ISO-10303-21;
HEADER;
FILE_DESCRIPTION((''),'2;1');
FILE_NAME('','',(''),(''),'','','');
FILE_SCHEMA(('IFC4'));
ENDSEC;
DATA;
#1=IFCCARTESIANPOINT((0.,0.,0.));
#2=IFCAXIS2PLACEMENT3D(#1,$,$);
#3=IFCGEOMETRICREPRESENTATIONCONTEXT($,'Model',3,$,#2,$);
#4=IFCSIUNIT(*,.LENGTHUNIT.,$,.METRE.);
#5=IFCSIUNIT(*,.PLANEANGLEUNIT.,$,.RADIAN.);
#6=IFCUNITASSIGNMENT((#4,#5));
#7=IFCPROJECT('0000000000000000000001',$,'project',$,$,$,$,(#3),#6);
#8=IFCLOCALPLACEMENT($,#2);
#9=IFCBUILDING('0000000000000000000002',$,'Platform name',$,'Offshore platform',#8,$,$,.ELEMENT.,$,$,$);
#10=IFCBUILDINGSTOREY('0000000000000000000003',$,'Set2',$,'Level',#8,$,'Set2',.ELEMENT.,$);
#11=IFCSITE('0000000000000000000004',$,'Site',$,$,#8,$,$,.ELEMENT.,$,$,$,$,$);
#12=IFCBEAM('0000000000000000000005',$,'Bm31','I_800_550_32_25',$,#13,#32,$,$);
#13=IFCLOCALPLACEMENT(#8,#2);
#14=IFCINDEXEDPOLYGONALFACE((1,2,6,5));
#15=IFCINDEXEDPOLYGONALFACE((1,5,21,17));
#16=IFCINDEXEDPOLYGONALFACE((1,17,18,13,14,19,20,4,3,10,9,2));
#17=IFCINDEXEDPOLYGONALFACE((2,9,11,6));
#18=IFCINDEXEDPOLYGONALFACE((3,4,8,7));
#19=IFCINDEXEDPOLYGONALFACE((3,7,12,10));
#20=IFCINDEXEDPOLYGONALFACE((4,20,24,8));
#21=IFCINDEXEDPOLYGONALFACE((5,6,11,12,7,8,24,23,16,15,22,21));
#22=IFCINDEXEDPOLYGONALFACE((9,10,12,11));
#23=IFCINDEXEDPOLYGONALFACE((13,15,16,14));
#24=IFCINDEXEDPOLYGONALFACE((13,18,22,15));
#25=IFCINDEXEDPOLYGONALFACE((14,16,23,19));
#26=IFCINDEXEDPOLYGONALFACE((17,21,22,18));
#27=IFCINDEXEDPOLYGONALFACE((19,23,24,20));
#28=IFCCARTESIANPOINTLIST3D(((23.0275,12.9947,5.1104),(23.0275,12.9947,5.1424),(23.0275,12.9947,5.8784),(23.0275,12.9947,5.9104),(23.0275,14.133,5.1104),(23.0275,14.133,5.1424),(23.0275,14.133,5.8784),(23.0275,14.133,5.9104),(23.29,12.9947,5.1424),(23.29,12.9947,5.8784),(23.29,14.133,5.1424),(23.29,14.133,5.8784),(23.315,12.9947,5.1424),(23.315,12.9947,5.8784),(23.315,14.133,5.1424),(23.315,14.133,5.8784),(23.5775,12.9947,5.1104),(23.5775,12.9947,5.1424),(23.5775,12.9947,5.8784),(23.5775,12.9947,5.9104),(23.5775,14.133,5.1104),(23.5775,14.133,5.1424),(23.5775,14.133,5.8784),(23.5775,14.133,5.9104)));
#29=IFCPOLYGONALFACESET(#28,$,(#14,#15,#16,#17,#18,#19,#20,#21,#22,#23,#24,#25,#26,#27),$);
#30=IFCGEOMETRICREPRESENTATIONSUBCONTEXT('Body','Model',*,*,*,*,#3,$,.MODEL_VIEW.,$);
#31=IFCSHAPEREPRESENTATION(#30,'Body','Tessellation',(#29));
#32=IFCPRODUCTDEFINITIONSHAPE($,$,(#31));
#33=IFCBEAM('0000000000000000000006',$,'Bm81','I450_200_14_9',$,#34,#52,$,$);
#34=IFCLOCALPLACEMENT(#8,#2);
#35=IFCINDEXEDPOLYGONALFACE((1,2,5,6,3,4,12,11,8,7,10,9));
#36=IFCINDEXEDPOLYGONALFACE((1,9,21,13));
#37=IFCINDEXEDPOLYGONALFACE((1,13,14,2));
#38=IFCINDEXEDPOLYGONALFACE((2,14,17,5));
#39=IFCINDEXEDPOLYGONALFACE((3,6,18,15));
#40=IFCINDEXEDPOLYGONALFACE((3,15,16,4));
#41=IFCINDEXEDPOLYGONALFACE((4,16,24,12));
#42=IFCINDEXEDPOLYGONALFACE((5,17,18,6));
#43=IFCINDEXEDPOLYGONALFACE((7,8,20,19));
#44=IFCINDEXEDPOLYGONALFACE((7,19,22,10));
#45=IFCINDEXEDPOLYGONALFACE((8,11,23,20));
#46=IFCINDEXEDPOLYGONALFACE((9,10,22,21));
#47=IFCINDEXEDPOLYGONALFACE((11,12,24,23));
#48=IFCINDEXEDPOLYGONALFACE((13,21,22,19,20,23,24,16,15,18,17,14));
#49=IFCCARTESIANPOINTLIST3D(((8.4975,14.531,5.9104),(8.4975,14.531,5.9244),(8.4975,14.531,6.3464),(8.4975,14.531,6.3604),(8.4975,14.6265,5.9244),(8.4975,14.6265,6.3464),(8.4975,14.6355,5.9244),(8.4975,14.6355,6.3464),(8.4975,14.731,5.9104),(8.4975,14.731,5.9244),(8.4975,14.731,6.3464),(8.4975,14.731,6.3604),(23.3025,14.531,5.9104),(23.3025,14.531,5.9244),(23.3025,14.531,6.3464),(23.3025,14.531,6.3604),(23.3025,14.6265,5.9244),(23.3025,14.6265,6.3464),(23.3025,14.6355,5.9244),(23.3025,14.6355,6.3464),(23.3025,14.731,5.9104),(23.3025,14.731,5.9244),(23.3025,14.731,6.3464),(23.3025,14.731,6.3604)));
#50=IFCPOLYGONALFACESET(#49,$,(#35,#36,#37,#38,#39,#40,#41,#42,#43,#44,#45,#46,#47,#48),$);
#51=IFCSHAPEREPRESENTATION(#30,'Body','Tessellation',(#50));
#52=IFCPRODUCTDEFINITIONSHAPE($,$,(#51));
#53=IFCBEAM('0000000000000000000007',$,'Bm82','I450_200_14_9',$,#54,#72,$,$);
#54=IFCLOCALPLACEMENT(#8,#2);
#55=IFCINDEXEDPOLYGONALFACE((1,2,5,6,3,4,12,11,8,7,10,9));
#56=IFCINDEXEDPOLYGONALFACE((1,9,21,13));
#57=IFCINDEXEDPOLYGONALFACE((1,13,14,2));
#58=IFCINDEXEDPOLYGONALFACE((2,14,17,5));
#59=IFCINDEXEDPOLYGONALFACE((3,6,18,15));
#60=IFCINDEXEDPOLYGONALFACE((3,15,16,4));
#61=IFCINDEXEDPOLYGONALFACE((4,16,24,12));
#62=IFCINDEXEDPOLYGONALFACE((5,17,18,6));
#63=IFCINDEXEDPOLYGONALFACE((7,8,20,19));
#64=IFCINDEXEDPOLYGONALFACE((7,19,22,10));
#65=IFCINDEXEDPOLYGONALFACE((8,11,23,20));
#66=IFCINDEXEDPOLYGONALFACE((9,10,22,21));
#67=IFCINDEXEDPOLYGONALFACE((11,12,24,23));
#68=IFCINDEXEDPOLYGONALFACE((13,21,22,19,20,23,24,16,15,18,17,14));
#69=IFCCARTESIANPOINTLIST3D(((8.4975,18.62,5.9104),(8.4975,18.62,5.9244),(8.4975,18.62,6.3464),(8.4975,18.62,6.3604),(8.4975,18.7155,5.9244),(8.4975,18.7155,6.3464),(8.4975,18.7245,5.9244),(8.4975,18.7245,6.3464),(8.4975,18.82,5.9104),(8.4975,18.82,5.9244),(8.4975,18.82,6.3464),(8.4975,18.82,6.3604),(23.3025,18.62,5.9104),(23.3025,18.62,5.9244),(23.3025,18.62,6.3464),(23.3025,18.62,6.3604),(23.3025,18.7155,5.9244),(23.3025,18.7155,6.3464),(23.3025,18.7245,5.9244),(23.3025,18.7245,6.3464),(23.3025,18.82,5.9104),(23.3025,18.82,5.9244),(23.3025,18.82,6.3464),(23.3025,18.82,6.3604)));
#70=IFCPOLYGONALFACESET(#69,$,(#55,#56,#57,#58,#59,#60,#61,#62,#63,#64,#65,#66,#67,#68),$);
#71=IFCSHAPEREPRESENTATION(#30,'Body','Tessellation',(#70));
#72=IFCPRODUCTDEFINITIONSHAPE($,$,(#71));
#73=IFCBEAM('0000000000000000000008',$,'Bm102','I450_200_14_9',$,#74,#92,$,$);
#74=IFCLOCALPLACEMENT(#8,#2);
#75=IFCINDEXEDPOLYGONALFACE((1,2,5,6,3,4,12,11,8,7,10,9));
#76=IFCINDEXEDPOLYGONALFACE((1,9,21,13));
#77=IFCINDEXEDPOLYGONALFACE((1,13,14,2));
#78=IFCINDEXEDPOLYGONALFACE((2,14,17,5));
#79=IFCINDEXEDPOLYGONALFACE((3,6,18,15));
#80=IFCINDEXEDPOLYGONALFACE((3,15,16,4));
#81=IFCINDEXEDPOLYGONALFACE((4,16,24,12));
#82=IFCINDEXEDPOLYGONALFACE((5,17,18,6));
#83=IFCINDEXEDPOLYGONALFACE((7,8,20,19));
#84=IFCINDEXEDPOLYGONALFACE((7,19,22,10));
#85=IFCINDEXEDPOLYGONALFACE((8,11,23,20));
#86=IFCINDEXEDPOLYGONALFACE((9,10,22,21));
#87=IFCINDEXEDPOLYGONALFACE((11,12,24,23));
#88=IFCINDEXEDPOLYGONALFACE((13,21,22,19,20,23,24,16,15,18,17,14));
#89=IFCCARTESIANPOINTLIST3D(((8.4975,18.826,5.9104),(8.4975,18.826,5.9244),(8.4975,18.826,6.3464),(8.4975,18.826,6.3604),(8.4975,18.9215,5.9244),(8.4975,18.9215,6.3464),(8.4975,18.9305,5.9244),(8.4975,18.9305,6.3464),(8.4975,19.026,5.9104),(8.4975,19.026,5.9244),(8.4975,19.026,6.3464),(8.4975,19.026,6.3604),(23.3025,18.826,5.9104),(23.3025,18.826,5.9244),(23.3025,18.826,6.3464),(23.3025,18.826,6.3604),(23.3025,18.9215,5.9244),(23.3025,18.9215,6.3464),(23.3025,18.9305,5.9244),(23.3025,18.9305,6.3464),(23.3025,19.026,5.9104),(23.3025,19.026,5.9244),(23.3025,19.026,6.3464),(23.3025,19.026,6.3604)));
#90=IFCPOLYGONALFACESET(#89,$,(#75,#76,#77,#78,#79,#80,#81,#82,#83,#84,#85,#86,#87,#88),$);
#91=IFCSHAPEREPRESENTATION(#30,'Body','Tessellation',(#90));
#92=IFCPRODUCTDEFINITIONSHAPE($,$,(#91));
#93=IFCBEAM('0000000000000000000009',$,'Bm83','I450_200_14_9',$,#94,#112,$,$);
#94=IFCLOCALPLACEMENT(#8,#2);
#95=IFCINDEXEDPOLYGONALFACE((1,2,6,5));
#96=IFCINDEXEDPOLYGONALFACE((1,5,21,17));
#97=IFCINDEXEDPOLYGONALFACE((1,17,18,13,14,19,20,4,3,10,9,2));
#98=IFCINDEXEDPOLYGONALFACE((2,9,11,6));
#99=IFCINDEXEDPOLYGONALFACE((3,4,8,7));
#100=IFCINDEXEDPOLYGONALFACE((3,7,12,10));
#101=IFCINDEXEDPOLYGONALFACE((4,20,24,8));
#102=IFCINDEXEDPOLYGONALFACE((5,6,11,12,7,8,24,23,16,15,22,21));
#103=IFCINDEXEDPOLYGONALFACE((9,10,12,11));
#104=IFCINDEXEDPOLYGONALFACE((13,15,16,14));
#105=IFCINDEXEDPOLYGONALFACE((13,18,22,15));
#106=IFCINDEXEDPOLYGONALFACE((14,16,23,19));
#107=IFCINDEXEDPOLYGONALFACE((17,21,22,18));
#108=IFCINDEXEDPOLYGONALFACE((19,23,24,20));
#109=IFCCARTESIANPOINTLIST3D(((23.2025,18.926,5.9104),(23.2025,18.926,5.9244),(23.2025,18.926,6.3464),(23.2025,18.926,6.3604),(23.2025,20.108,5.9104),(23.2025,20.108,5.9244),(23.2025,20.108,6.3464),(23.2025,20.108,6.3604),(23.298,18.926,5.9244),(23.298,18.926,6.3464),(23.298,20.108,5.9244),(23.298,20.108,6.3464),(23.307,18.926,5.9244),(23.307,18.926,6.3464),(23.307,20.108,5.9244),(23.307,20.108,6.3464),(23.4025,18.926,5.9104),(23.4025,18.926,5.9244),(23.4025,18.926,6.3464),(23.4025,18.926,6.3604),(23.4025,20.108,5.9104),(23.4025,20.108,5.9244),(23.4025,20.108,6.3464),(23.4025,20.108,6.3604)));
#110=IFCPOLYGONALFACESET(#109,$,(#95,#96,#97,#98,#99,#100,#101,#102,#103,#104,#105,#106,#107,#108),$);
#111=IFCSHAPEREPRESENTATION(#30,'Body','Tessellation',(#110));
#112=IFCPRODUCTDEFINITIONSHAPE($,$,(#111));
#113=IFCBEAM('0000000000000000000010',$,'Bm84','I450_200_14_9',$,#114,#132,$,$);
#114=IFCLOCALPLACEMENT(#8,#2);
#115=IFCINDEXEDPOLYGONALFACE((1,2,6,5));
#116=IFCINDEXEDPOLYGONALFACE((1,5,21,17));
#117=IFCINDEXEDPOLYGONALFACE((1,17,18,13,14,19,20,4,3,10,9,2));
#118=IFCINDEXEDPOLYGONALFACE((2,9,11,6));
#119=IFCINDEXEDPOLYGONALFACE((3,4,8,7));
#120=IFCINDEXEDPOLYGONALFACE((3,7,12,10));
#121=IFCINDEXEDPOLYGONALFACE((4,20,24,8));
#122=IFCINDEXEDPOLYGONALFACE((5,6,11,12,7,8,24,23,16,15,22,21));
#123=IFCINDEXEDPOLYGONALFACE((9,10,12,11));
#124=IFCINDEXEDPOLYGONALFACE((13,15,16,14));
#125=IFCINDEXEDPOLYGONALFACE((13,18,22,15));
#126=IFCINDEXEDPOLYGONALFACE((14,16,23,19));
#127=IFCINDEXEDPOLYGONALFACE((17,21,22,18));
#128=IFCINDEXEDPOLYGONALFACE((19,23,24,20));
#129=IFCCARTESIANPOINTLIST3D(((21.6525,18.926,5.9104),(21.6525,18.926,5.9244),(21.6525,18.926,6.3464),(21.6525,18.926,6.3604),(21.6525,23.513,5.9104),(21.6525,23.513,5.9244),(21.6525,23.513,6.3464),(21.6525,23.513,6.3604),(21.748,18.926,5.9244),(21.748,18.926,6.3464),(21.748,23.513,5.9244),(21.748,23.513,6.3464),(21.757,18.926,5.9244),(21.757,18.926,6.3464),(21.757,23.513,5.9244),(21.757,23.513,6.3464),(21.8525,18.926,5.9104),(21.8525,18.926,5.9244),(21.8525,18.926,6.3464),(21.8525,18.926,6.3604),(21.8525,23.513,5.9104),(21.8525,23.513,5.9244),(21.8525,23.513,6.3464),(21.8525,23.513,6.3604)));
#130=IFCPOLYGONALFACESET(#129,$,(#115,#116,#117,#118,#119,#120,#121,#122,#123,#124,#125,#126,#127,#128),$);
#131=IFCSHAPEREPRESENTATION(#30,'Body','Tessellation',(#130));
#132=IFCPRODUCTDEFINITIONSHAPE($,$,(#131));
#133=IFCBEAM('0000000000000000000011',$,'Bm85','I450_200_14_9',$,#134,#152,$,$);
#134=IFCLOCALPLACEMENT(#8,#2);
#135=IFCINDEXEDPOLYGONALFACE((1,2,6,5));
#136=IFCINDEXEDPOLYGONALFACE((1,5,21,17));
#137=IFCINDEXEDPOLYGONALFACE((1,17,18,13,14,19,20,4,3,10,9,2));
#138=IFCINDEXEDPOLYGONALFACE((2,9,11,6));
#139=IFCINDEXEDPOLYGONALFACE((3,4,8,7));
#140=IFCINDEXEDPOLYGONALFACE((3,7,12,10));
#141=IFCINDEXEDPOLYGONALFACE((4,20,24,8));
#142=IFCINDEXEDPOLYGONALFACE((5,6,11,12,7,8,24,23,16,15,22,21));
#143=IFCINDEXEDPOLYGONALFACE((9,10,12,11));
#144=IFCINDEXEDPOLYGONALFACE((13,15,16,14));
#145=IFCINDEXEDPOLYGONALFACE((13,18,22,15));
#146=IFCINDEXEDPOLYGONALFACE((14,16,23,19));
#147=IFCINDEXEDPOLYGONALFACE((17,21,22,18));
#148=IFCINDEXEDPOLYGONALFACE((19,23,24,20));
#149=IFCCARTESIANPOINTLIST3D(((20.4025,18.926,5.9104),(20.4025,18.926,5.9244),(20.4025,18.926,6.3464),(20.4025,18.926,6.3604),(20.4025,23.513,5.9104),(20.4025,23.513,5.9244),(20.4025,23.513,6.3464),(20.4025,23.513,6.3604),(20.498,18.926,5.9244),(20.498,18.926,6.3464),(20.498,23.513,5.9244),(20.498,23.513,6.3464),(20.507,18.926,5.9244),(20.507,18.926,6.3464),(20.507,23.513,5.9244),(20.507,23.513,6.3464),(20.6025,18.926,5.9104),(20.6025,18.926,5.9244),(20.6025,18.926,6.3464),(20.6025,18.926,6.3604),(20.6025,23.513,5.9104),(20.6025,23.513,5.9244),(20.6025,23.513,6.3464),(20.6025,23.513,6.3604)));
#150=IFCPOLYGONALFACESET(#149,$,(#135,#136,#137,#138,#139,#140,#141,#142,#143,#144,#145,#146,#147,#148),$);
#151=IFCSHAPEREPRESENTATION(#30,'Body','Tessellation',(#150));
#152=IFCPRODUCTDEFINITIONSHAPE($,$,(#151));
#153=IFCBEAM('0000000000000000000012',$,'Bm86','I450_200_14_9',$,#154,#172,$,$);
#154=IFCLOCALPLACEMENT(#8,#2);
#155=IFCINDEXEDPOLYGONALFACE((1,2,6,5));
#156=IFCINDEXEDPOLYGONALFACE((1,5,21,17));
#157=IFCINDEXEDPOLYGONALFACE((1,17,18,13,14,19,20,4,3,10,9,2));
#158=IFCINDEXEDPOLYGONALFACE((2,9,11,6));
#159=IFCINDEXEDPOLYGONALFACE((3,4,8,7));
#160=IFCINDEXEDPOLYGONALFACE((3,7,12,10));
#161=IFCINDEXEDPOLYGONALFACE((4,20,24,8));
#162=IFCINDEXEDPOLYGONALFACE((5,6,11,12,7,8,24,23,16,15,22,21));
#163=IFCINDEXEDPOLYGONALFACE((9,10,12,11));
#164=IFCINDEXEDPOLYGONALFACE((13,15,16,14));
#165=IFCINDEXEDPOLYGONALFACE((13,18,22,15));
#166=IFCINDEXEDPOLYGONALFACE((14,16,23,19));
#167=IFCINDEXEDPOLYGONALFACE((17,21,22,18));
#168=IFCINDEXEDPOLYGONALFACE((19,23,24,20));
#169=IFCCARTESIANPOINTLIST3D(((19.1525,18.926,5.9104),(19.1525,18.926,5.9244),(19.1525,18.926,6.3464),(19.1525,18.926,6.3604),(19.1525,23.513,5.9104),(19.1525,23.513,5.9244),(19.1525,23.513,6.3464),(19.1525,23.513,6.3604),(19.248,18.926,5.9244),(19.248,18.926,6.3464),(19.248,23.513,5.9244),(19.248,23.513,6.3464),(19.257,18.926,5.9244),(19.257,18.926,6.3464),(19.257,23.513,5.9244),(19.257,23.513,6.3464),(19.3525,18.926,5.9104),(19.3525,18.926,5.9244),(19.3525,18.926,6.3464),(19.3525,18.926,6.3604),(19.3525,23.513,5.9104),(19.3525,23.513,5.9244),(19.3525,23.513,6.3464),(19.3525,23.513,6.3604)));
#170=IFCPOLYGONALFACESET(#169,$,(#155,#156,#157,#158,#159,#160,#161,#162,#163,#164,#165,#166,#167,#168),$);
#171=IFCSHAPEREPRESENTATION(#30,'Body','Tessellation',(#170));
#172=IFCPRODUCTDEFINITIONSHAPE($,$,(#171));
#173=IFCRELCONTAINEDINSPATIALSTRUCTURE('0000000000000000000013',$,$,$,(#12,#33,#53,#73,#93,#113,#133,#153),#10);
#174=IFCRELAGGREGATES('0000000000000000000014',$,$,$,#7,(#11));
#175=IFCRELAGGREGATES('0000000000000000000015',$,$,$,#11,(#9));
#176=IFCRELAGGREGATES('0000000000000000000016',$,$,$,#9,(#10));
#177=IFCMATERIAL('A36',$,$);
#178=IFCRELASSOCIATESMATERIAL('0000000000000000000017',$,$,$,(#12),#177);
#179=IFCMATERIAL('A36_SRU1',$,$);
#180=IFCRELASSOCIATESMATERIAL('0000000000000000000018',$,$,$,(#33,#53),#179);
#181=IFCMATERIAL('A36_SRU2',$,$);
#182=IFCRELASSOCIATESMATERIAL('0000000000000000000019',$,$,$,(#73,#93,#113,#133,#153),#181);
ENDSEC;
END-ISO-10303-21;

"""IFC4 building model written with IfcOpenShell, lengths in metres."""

from ifc_helpers import new_model, si_unit, frame, origin, origin_2d, place, context, subcontext, project, spatial, i_section, extrude, source, transform, mapped, material, element, save


model = new_model("IFC4")

# Units and contexts
model_context = context("Model", 3, world=origin())
body_context = subcontext(model_context, "Body", "Model", "MODEL_VIEW")
ifc_project = project(units=[si_unit("LENGTHUNIT", "METRE"), si_unit("PLANEANGLEUNIT", "RADIAN")], contexts=[model_context])

# Site, building, storey
placement_1 = place(None, origin())
site = spatial("IfcSite", under=ifc_project, at=placement_1, Name="Site", CompositionType="ELEMENT")
building = spatial("IfcBuilding", under=site, at=placement_1, Name="Platform name", ObjectType="Offshore platform", CompositionType="ELEMENT")
storey = spatial("IfcBuildingStorey", under=building, at=placement_1, Name="Set2", ObjectType="Level", LongName="Set2", CompositionType="ELEMENT")

# Beams
ifc_material_1 = material(Name="A36")
shared_shape_1 = source(origin(), body_context, "Body", "SweptSolid", [
    extrude(i_section(OverallWidth=0.55, OverallDepth=0.8, WebThickness=0.025, FlangeThickness=0.032, FilletRadius=0.0, at=origin_2d()), frame((0.0, 0.0, 0.0), z_axis=(0.0, -1.0, 0.0), x_axis=(1.0, 0.0, 0.0)), (0.0, 0.0, 1.0), 1.1383),
])
placement_2 = place(None, origin())
placement_3 = place(placement_2, origin())
placement_4 = place(placement_3, origin())
beam_1_placement = place(placement_4, frame((23.3025, 14.133, 5.5104)))
element("IfcBeam", 1, at=beam_1_placement, inside=storey, material=ifc_material_1, Name="Bm31", Description="I_800_550_32_25", context=body_context, shape_type="MappedRepresentation", body=[
    mapped(shared_shape_1, transform((0.0, 0.0, 0.0), scale=1.0)),
])
ifc_material_2 = material(Name="A36_SRU1")
shared_shape_2 = source(origin(), body_context, "Body", "SweptSolid", [
    extrude(i_section(OverallWidth=0.2, OverallDepth=0.45, WebThickness=0.009, FlangeThickness=0.014, FilletRadius=0.0, at=origin_2d()), frame((0.0, 0.0, 0.0), z_axis=(-1.0, 0.0, 0.0), x_axis=(0.0, -1.0, 0.0)), (0.0, 0.0, 1.0), 14.805),
])
placement_5 = place(None, origin())
placement_6 = place(placement_5, origin())
placement_7 = place(placement_6, origin())
beam_2_placement = place(placement_7, frame((23.3025, 14.631, 6.1354)))
element("IfcBeam", 2, at=beam_2_placement, inside=storey, material=ifc_material_2, Name="Bm81", Description="I450_200_14_9", context=body_context, shape_type="MappedRepresentation", body=[
    mapped(shared_shape_2, transform((0.0, 0.0, 0.0), scale=1.0)),
])
shared_shape_3 = source(origin(), body_context, "Body", "SweptSolid", [
    extrude(i_section(OverallWidth=0.2, OverallDepth=0.45, WebThickness=0.009, FlangeThickness=0.014, FilletRadius=0.0, at=origin_2d()), frame((0.0, 0.0, 0.0), z_axis=(-1.0, 0.0, 0.0), x_axis=(0.0, -1.0, 0.0)), (0.0, 0.0, 1.0), 14.805),
])
placement_8 = place(None, origin())
placement_9 = place(placement_8, origin())
placement_10 = place(placement_9, origin())
beam_3_placement = place(placement_10, frame((23.3025, 18.72, 6.1354)))
element("IfcBeam", 3, at=beam_3_placement, inside=storey, material=ifc_material_2, Name="Bm82", Description="I450_200_14_9", context=body_context, shape_type="MappedRepresentation", body=[
    mapped(shared_shape_3, transform((0.0, 0.0, 0.0), scale=1.0)),
])
ifc_material_3 = material(Name="A36_SRU2")
shared_shape_4 = source(origin(), body_context, "Body", "SweptSolid", [
    extrude(i_section(OverallWidth=0.2, OverallDepth=0.45, WebThickness=0.009, FlangeThickness=0.014, FilletRadius=0.0, at=origin_2d()), frame((0.0, 0.0, 0.0), z_axis=(-1.0, 0.0, 0.0), x_axis=(0.0, -1.0, 0.0)), (0.0, 0.0, 1.0), 14.805),
])
placement_11 = place(None, origin())
placement_12 = place(placement_11, origin())
placement_13 = place(placement_12, origin())
beam_4_placement = place(placement_13, frame((23.3025, 18.926, 6.1354)))
element("IfcBeam", 4, at=beam_4_placement, inside=storey, material=ifc_material_3, Name="Bm102", Description="I450_200_14_9", context=body_context, shape_type="MappedRepresentation", body=[
    mapped(shared_shape_4, transform((0.0, 0.0, 0.0), scale=1.0)),
])
shared_shape_5 = source(origin(), body_context, "Body", "SweptSolid", [
    extrude(i_section(OverallWidth=0.2, OverallDepth=0.45, WebThickness=0.009, FlangeThickness=0.014, FilletRadius=0.0, at=origin_2d()), frame((0.0, 0.0, 0.0), z_axis=(0.0, 1.0, 0.0), x_axis=(-1.0, 0.0, 0.0)), (0.0, 0.0, 1.0), 1.182),
])
placement_14 = place(None, origin())
placement_15 = place(placement_14, origin())
placement_16 = place(placement_15, origin())
beam_5_placement = place(placement_16, frame((23.3025, 18.926, 6.1354)))
element("IfcBeam", 5, at=beam_5_placement, inside=storey, material=ifc_material_3, Name="Bm83", Description="I450_200_14_9", context=body_context, shape_type="MappedRepresentation", body=[
    mapped(shared_shape_5, transform((0.0, 0.0, 0.0), scale=1.0)),
])
shared_shape_6 = source(origin(), body_context, "Body", "SweptSolid", [
    extrude(i_section(OverallWidth=0.2, OverallDepth=0.45, WebThickness=0.009, FlangeThickness=0.014, FilletRadius=0.0, at=origin_2d()), frame((0.0, 0.0, 0.0), z_axis=(0.0, 1.0, 0.0), x_axis=(-1.0, 0.0, 0.0)), (0.0, 0.0, 1.0), 4.587),
])
placement_17 = place(None, origin())
placement_18 = place(placement_17, origin())
placement_19 = place(placement_18, origin())
beam_6_placement = place(placement_19, frame((21.7525, 18.926, 6.1354)))
element("IfcBeam", 6, at=beam_6_placement, inside=storey, material=ifc_material_3, Name="Bm84", Description="I450_200_14_9", context=body_context, shape_type="MappedRepresentation", body=[
    mapped(shared_shape_6, transform((0.0, 0.0, 0.0), scale=1.0)),
])
shared_shape_7 = source(origin(), body_context, "Body", "SweptSolid", [
    extrude(i_section(OverallWidth=0.2, OverallDepth=0.45, WebThickness=0.009, FlangeThickness=0.014, FilletRadius=0.0, at=origin_2d()), frame((0.0, 0.0, 0.0), z_axis=(0.0, 1.0, 0.0), x_axis=(-1.0, 0.0, 0.0)), (0.0, 0.0, 1.0), 4.587),
])
placement_20 = place(None, origin())
placement_21 = place(placement_20, origin())
placement_22 = place(placement_21, origin())
beam_7_placement = place(placement_22, frame((20.5025, 18.926, 6.1354)))
element("IfcBeam", 7, at=beam_7_placement, inside=storey, material=ifc_material_3, Name="Bm85", Description="I450_200_14_9", context=body_context, shape_type="MappedRepresentation", body=[
    mapped(shared_shape_7, transform((0.0, 0.0, 0.0), scale=1.0)),
])
shared_shape_8 = source(origin(), body_context, "Body", "SweptSolid", [
    extrude(i_section(OverallWidth=0.2, OverallDepth=0.45, WebThickness=0.009, FlangeThickness=0.014, FilletRadius=0.0, at=origin_2d()), frame((0.0, 0.0, 0.0), z_axis=(0.0, 1.0, 0.0), x_axis=(-1.0, 0.0, 0.0)), (0.0, 0.0, 1.0), 4.587),
])
placement_23 = place(None, origin())
placement_24 = place(placement_23, origin())
placement_25 = place(placement_24, origin())
beam_8_placement = place(placement_25, frame((19.2525, 18.926, 6.1354)))
element("IfcBeam", 8, at=beam_8_placement, inside=storey, material=ifc_material_3, Name="Bm86", Description="I450_200_14_9", context=body_context, shape_type="MappedRepresentation", body=[
    mapped(shared_shape_8, transform((0.0, 0.0, 0.0), scale=1.0)),
])

save(model, "model.ifc")
